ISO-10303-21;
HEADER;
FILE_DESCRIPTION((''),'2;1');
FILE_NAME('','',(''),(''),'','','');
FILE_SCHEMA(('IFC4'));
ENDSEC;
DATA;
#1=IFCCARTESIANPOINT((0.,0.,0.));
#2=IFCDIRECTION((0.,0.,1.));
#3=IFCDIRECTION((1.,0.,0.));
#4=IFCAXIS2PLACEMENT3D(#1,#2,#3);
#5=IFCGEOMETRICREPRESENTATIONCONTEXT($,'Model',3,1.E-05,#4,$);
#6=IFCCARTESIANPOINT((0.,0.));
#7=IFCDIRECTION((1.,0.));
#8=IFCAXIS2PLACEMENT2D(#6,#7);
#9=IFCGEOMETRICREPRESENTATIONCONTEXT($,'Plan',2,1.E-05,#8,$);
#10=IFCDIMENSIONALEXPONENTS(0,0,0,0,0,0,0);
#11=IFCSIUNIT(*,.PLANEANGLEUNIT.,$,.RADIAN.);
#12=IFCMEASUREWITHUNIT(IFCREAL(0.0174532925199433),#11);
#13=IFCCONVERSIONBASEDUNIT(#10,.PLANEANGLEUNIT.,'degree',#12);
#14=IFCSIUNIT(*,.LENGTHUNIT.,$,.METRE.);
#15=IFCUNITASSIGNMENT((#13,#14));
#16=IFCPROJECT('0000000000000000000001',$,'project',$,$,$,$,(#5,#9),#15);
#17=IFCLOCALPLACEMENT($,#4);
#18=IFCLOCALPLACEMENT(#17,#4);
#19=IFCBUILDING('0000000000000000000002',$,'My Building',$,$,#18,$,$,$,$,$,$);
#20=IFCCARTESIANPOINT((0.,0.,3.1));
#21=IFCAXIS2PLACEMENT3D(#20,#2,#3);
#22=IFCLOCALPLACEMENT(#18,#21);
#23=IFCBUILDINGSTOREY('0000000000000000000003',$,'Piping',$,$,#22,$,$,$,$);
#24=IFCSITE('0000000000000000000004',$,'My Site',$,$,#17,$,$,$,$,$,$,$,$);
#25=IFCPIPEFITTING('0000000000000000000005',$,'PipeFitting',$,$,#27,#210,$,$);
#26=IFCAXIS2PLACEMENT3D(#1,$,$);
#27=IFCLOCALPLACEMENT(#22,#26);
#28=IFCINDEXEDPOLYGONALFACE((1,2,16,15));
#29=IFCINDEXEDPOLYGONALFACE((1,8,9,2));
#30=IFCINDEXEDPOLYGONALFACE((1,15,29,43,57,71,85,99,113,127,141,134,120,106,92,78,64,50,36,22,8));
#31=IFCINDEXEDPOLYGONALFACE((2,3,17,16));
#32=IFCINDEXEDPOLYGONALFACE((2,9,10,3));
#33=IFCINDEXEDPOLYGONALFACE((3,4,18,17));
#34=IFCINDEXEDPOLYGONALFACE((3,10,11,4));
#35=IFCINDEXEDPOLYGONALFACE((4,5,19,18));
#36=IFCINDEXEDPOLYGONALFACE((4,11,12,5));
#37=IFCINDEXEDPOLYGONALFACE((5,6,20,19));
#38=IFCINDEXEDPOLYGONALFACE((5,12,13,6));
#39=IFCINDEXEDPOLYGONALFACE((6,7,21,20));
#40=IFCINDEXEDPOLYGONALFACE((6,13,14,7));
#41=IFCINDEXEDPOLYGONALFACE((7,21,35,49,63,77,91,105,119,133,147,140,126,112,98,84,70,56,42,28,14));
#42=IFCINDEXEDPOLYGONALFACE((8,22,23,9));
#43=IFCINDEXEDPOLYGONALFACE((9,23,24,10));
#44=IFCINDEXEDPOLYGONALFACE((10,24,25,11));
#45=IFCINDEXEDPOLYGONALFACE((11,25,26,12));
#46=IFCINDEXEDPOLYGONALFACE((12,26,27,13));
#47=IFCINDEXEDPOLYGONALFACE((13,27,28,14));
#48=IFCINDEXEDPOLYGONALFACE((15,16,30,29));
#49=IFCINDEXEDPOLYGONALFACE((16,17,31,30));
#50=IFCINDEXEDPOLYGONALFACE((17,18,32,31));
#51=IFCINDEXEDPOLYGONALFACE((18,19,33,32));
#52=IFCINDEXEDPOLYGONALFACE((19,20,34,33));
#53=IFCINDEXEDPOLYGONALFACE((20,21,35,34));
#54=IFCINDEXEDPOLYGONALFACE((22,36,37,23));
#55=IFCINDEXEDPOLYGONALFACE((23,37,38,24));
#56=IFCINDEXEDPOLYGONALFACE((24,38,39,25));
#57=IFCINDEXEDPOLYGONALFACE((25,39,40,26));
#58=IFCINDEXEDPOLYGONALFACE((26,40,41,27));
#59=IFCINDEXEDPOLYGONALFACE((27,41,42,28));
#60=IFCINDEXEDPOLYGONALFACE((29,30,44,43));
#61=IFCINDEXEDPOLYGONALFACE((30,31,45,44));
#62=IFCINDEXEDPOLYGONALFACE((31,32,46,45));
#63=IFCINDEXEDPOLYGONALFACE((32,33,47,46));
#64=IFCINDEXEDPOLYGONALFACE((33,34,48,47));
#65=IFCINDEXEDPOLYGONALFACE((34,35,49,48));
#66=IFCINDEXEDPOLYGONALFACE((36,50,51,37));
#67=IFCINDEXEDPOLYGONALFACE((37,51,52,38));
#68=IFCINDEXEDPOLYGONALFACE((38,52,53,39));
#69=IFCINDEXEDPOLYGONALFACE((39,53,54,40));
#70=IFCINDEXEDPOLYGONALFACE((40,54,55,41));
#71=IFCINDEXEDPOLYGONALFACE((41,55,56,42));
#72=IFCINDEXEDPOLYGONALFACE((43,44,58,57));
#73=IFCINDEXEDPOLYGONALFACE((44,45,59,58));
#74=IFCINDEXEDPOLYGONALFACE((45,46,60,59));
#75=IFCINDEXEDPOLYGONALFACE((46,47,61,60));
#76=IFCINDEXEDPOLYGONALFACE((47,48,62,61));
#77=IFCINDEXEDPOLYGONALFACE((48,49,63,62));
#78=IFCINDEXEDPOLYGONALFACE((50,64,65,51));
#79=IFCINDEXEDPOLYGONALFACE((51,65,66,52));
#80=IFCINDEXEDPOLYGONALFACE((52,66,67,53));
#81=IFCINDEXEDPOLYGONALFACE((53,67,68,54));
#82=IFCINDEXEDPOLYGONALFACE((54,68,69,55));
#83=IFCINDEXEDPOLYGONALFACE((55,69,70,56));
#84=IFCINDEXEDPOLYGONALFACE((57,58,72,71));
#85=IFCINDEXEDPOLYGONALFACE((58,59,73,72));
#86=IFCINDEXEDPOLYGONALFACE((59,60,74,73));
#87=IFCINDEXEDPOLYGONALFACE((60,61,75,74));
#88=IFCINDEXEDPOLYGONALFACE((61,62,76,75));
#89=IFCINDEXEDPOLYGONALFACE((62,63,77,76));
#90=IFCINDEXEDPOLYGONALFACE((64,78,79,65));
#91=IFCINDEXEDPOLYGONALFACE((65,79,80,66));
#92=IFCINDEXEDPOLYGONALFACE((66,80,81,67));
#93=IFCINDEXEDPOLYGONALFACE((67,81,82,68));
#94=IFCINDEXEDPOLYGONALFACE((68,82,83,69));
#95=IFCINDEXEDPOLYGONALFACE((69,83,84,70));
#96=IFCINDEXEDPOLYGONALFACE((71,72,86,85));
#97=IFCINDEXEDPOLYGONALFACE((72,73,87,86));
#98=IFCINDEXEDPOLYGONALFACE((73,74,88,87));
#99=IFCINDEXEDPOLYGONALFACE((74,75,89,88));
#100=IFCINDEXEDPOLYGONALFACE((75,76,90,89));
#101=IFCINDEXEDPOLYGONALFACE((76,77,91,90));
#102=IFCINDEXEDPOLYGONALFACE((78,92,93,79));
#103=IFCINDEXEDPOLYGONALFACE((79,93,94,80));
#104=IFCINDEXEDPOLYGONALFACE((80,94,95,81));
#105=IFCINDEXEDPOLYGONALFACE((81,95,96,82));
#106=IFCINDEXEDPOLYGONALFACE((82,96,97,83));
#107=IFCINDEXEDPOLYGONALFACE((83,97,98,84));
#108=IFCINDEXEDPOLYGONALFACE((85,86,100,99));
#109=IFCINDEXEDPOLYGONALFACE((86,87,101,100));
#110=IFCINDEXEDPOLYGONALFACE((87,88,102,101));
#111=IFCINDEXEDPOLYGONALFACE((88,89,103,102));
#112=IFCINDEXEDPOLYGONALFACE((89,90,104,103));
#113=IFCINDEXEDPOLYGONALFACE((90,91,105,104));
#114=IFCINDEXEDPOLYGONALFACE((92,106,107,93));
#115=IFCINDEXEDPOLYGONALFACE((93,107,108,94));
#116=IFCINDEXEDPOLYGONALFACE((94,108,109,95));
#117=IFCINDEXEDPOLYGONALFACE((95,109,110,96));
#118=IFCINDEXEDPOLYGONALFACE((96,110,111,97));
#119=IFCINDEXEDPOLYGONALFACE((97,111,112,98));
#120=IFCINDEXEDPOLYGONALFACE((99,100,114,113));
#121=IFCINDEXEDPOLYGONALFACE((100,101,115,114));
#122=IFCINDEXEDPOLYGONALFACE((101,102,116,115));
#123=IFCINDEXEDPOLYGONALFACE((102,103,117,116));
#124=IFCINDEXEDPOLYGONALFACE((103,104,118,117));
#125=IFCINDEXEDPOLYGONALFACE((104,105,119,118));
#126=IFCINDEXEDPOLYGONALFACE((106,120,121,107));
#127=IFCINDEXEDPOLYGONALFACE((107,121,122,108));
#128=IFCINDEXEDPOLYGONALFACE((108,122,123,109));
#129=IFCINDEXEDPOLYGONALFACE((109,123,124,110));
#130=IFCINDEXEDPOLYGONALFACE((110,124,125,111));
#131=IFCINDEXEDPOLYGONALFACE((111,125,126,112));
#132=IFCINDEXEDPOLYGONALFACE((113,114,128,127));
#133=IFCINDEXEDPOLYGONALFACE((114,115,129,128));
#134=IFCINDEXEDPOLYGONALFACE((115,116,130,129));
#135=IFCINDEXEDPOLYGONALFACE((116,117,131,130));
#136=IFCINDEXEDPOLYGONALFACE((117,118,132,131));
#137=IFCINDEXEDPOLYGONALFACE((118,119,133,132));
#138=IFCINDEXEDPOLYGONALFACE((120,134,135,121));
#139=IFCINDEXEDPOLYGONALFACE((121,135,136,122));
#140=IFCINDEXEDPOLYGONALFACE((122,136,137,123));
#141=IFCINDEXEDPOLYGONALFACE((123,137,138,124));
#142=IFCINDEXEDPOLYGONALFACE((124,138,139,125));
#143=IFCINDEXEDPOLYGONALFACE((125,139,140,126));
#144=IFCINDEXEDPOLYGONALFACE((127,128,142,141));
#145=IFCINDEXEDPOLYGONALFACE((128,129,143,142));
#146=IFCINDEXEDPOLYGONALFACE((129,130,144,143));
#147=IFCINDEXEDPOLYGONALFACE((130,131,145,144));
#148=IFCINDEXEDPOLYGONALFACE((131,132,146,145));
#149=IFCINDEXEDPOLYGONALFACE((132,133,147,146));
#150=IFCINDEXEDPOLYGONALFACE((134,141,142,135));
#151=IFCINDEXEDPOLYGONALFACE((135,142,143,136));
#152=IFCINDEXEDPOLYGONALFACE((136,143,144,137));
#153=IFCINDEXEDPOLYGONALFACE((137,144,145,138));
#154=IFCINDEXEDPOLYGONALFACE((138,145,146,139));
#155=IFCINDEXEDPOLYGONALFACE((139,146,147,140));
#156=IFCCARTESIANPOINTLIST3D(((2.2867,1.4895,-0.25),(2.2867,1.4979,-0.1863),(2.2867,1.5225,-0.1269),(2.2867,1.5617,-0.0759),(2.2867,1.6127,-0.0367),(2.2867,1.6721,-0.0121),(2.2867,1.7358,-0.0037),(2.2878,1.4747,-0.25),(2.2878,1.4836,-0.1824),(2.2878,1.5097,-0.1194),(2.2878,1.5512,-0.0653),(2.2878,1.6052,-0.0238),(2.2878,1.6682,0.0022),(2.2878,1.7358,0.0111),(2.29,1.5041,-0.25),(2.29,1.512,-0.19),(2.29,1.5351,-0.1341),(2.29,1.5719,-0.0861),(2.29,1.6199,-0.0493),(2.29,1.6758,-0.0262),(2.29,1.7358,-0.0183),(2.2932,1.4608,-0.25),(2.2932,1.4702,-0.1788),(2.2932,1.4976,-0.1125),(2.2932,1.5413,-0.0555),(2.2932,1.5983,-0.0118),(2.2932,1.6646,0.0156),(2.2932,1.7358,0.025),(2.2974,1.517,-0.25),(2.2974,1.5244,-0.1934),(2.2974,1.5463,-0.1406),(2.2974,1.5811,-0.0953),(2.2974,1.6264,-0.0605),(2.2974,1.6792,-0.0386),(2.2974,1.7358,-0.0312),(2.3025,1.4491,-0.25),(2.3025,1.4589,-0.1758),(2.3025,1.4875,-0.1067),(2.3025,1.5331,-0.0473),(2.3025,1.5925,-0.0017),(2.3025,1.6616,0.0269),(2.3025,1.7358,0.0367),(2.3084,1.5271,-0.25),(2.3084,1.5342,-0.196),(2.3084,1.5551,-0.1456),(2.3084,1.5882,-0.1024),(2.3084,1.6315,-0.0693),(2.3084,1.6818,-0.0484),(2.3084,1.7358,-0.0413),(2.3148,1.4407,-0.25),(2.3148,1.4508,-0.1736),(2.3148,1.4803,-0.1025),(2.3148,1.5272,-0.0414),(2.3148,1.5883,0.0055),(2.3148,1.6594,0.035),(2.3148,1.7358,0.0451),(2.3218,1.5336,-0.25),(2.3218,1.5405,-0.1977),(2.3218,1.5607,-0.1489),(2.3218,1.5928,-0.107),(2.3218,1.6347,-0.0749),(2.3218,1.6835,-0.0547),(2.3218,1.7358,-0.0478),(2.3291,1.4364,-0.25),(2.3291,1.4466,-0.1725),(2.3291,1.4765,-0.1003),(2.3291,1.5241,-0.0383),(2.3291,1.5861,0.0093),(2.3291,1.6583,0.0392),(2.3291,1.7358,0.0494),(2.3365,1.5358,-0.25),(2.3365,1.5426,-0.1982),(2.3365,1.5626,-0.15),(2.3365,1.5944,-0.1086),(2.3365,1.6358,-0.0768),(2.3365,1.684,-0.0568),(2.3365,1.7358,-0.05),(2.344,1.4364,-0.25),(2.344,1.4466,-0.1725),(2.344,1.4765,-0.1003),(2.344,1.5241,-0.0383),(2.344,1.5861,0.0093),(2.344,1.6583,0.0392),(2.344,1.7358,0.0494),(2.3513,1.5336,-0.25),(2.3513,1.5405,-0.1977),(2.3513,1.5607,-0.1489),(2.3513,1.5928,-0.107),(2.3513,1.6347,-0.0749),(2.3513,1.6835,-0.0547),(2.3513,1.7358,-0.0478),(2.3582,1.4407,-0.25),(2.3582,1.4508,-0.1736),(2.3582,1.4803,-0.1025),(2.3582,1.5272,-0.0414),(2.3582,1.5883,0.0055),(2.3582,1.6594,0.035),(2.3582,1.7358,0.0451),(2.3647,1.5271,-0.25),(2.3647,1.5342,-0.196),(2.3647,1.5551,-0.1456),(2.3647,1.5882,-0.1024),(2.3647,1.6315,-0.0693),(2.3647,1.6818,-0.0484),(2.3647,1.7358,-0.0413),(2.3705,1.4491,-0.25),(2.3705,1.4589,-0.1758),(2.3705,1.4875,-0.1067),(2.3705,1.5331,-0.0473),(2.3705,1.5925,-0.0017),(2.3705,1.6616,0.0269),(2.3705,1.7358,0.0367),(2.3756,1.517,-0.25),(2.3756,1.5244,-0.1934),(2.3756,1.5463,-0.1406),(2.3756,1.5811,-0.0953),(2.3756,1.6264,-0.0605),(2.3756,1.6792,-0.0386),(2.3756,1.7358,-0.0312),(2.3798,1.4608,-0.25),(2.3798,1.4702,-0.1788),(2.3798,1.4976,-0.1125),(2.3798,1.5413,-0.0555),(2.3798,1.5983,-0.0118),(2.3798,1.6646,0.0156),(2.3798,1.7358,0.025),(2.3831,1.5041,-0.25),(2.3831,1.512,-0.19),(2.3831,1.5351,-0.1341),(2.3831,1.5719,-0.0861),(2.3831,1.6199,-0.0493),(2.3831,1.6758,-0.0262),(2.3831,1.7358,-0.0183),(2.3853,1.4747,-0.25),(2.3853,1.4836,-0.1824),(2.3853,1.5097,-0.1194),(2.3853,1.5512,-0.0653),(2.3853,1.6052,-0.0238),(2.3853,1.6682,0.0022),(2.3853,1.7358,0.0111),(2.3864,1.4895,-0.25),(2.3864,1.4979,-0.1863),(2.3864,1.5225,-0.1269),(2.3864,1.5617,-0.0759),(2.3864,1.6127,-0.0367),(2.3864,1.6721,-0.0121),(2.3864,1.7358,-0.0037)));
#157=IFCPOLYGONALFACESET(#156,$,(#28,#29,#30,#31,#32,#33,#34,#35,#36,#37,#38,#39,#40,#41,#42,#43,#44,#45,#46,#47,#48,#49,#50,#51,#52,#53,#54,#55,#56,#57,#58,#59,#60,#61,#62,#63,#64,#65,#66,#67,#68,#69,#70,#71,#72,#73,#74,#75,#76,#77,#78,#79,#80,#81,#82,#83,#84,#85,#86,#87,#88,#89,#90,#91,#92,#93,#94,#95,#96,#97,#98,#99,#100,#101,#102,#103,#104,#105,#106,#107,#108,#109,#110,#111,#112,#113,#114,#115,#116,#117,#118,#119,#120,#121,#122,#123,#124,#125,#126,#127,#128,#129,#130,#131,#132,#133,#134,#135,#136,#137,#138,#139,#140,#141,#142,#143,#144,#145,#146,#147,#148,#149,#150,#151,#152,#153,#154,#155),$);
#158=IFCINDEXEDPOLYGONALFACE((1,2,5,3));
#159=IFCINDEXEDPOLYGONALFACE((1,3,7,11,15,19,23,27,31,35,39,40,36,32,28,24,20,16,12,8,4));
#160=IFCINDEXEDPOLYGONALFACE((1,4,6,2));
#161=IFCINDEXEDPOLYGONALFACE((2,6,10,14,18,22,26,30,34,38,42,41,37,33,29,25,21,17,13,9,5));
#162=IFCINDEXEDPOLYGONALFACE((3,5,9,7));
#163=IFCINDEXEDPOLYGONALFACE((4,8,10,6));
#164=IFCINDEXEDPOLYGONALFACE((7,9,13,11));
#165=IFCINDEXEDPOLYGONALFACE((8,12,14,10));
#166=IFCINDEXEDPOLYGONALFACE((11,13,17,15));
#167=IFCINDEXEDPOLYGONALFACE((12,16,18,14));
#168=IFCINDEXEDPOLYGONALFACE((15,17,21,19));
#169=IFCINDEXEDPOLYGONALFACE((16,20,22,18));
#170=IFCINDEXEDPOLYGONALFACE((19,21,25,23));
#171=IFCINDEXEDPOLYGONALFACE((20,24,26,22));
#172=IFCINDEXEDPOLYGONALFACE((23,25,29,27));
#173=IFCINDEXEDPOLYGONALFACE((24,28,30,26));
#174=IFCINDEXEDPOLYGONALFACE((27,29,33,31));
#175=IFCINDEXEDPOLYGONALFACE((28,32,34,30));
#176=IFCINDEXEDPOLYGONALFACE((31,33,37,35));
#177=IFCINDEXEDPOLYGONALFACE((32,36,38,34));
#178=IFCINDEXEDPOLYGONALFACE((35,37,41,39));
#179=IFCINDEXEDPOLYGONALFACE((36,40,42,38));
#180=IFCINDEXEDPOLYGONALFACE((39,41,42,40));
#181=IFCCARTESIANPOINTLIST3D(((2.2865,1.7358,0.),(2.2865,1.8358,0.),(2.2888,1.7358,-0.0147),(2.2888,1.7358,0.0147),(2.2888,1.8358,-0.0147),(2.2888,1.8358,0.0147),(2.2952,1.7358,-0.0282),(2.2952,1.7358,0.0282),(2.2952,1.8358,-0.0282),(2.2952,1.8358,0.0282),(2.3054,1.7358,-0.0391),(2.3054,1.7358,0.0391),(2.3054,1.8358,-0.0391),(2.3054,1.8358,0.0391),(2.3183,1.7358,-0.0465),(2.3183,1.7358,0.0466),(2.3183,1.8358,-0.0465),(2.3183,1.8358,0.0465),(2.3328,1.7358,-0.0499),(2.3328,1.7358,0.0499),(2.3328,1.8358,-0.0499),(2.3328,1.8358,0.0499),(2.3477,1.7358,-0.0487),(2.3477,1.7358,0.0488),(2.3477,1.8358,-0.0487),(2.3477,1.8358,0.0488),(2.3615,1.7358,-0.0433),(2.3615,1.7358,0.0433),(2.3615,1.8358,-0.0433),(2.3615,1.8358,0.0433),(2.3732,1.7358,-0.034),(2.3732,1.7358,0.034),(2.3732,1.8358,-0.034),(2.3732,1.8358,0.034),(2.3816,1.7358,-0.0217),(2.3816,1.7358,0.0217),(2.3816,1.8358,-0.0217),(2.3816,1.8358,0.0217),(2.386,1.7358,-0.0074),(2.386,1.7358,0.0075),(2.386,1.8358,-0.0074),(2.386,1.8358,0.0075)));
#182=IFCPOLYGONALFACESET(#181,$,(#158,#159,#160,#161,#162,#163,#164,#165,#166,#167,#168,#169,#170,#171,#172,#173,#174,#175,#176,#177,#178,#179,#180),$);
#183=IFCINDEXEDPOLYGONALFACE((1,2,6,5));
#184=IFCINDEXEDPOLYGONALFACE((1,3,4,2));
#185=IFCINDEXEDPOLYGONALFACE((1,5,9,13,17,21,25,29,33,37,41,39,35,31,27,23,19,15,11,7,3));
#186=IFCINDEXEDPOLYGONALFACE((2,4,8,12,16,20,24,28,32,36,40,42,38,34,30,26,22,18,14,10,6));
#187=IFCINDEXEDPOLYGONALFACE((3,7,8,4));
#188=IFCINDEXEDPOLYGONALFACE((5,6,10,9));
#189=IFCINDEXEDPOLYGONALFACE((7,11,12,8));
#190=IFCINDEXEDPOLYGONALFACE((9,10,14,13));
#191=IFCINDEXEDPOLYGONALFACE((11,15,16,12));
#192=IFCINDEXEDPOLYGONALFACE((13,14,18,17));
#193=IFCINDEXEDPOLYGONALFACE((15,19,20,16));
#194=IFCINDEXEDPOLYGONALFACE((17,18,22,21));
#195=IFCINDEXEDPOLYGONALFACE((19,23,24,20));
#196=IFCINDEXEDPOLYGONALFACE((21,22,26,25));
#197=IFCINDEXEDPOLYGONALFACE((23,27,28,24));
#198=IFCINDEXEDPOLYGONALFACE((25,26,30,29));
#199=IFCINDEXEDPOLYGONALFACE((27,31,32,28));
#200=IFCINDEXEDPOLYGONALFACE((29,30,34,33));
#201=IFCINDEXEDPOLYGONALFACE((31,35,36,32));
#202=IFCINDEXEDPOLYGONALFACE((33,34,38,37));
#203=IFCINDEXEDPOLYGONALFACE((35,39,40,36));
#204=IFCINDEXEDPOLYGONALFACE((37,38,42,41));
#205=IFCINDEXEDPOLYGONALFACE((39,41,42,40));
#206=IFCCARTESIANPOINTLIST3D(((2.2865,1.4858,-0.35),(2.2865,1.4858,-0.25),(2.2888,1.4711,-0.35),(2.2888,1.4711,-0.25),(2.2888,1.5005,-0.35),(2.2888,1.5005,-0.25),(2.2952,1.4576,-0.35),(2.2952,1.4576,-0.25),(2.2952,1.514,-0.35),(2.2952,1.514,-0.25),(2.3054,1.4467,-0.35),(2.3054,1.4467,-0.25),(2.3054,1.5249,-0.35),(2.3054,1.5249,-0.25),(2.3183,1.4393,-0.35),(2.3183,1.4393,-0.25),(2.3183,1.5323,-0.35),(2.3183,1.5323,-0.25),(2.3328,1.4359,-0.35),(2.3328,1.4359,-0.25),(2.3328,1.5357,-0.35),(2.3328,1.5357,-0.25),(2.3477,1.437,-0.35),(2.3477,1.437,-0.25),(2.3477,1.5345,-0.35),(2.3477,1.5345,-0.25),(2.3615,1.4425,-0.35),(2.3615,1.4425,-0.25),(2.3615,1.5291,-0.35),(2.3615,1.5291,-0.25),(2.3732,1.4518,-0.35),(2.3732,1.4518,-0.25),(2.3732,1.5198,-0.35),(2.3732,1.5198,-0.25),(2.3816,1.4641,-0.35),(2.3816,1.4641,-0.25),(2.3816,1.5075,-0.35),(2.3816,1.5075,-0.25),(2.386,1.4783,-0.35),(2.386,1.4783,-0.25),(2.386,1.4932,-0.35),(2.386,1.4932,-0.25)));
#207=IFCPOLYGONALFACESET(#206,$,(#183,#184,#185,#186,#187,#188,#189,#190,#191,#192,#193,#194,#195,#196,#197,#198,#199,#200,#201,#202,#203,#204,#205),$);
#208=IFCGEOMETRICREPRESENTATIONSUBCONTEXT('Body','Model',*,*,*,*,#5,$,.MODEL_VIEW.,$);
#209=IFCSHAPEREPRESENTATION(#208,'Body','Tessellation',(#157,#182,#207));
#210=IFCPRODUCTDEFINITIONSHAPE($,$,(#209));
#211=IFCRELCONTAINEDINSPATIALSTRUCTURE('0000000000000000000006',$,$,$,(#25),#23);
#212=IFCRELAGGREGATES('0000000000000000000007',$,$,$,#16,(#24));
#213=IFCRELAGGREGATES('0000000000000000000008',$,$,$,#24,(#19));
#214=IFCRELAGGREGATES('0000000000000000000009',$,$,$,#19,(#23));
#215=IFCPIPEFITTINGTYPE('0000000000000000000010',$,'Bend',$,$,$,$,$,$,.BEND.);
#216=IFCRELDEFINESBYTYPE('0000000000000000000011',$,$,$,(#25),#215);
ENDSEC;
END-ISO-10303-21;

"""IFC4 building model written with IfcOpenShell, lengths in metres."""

from ifc_helpers import new_model, entity, si_unit, converted_unit, frame, origin_with_axes, origin_2d_with_axis, place, context, subcontext, project, spatial, circle, extrude, source, transform, mapped, type_object, type_shapes, element, save


model = new_model("IFC4")

# Units and contexts
model_context = context("Model", 3, precision=1e-05, world=origin_with_axes())
plan_context = context("Plan", 2, precision=1e-05, world=origin_2d_with_axis())
body_context = subcontext(model_context, "Body", "Model", "MODEL_VIEW")
ifc_project = project(units=[converted_unit("PLANEANGLEUNIT", "degree", entity("IfcReal", 0.0174532925199433), si_unit("PLANEANGLEUNIT", "RADIAN"), dimensions=[0, 0, 0, 0, 0, 0, 0]), si_unit("LENGTHUNIT", "METRE")], contexts=[model_context, plan_context])

# Site, building, storey
site_placement = place(None, origin_with_axes())
site = spatial("IfcSite", under=ifc_project, at=site_placement, Name="My Site")
building_placement = place(site_placement, origin_with_axes())
building = spatial("IfcBuilding", under=site, at=building_placement, Name="My Building")
storey_placement = place(building_placement, frame((0.0, 0.0, 3.1), z_axis=(0.0, 0.0, 1.0), x_axis=(1.0, 0.0, 0.0)))
storey = spatial("IfcBuildingStorey", under=building, at=storey_placement, Name="Piping")

# Pipe fitting
pipe_fitting_type_1 = type_object("IfcPipeFittingType", Name="Bend", PredefinedType="BEND")
shared_shape_1 = source(origin_with_axes(), body_context, "Body", "SolidModel", [
    entity("IfcSweptDiskSolid", entity("IfcIndexedPolyCurve", entity("IfcCartesianPointList3D", [[0.0, 0.0, -0.1], [0.0, -0.0732, -0.2768], [0.0, -0.25, -0.35]]), [entity("IfcArcIndex", [1, 2, 3])]), 0.05),
    extrude(circle(Radius=0.05), origin_with_axes(), (0.0, 0.0, -1.0), 0.1),
    extrude(circle(Radius=0.05), frame((0.0, -0.25, -0.35), z_axis=(0.0, -1.0, 0.000022), x_axis=(1.0, 0.0, 0.0)), (0.0, 0.0, 1.0), 0.1),
])
type_shapes(pipe_fitting_type_1, [shared_shape_1])
for number, where, z_axis, x_axis, name in (
    (1, (2.3365, 1.8358, 0.0), (0.0, 1.0, -0.000022), (-1.0, 0.0, 0.0), "PipeFitting"),
):
    element("IfcPipeFitting", number, at=place(storey_placement, frame(where, z_axis=z_axis, x_axis=x_axis)), inside=storey, type_object=pipe_fitting_type_1, Name=name, context=body_context, shape_type="MappedRepresentation", body=[
        mapped(shared_shape_1, transform((0.0, 0.0, 0.0), x_axis=(1.0, 0.0, 0.0), y_axis=(0.0, 1.0, 0.0), z_axis=(0.0, 0.0, 1.0), scale=1.0)),
    ])

save(model, "model.ifc")
